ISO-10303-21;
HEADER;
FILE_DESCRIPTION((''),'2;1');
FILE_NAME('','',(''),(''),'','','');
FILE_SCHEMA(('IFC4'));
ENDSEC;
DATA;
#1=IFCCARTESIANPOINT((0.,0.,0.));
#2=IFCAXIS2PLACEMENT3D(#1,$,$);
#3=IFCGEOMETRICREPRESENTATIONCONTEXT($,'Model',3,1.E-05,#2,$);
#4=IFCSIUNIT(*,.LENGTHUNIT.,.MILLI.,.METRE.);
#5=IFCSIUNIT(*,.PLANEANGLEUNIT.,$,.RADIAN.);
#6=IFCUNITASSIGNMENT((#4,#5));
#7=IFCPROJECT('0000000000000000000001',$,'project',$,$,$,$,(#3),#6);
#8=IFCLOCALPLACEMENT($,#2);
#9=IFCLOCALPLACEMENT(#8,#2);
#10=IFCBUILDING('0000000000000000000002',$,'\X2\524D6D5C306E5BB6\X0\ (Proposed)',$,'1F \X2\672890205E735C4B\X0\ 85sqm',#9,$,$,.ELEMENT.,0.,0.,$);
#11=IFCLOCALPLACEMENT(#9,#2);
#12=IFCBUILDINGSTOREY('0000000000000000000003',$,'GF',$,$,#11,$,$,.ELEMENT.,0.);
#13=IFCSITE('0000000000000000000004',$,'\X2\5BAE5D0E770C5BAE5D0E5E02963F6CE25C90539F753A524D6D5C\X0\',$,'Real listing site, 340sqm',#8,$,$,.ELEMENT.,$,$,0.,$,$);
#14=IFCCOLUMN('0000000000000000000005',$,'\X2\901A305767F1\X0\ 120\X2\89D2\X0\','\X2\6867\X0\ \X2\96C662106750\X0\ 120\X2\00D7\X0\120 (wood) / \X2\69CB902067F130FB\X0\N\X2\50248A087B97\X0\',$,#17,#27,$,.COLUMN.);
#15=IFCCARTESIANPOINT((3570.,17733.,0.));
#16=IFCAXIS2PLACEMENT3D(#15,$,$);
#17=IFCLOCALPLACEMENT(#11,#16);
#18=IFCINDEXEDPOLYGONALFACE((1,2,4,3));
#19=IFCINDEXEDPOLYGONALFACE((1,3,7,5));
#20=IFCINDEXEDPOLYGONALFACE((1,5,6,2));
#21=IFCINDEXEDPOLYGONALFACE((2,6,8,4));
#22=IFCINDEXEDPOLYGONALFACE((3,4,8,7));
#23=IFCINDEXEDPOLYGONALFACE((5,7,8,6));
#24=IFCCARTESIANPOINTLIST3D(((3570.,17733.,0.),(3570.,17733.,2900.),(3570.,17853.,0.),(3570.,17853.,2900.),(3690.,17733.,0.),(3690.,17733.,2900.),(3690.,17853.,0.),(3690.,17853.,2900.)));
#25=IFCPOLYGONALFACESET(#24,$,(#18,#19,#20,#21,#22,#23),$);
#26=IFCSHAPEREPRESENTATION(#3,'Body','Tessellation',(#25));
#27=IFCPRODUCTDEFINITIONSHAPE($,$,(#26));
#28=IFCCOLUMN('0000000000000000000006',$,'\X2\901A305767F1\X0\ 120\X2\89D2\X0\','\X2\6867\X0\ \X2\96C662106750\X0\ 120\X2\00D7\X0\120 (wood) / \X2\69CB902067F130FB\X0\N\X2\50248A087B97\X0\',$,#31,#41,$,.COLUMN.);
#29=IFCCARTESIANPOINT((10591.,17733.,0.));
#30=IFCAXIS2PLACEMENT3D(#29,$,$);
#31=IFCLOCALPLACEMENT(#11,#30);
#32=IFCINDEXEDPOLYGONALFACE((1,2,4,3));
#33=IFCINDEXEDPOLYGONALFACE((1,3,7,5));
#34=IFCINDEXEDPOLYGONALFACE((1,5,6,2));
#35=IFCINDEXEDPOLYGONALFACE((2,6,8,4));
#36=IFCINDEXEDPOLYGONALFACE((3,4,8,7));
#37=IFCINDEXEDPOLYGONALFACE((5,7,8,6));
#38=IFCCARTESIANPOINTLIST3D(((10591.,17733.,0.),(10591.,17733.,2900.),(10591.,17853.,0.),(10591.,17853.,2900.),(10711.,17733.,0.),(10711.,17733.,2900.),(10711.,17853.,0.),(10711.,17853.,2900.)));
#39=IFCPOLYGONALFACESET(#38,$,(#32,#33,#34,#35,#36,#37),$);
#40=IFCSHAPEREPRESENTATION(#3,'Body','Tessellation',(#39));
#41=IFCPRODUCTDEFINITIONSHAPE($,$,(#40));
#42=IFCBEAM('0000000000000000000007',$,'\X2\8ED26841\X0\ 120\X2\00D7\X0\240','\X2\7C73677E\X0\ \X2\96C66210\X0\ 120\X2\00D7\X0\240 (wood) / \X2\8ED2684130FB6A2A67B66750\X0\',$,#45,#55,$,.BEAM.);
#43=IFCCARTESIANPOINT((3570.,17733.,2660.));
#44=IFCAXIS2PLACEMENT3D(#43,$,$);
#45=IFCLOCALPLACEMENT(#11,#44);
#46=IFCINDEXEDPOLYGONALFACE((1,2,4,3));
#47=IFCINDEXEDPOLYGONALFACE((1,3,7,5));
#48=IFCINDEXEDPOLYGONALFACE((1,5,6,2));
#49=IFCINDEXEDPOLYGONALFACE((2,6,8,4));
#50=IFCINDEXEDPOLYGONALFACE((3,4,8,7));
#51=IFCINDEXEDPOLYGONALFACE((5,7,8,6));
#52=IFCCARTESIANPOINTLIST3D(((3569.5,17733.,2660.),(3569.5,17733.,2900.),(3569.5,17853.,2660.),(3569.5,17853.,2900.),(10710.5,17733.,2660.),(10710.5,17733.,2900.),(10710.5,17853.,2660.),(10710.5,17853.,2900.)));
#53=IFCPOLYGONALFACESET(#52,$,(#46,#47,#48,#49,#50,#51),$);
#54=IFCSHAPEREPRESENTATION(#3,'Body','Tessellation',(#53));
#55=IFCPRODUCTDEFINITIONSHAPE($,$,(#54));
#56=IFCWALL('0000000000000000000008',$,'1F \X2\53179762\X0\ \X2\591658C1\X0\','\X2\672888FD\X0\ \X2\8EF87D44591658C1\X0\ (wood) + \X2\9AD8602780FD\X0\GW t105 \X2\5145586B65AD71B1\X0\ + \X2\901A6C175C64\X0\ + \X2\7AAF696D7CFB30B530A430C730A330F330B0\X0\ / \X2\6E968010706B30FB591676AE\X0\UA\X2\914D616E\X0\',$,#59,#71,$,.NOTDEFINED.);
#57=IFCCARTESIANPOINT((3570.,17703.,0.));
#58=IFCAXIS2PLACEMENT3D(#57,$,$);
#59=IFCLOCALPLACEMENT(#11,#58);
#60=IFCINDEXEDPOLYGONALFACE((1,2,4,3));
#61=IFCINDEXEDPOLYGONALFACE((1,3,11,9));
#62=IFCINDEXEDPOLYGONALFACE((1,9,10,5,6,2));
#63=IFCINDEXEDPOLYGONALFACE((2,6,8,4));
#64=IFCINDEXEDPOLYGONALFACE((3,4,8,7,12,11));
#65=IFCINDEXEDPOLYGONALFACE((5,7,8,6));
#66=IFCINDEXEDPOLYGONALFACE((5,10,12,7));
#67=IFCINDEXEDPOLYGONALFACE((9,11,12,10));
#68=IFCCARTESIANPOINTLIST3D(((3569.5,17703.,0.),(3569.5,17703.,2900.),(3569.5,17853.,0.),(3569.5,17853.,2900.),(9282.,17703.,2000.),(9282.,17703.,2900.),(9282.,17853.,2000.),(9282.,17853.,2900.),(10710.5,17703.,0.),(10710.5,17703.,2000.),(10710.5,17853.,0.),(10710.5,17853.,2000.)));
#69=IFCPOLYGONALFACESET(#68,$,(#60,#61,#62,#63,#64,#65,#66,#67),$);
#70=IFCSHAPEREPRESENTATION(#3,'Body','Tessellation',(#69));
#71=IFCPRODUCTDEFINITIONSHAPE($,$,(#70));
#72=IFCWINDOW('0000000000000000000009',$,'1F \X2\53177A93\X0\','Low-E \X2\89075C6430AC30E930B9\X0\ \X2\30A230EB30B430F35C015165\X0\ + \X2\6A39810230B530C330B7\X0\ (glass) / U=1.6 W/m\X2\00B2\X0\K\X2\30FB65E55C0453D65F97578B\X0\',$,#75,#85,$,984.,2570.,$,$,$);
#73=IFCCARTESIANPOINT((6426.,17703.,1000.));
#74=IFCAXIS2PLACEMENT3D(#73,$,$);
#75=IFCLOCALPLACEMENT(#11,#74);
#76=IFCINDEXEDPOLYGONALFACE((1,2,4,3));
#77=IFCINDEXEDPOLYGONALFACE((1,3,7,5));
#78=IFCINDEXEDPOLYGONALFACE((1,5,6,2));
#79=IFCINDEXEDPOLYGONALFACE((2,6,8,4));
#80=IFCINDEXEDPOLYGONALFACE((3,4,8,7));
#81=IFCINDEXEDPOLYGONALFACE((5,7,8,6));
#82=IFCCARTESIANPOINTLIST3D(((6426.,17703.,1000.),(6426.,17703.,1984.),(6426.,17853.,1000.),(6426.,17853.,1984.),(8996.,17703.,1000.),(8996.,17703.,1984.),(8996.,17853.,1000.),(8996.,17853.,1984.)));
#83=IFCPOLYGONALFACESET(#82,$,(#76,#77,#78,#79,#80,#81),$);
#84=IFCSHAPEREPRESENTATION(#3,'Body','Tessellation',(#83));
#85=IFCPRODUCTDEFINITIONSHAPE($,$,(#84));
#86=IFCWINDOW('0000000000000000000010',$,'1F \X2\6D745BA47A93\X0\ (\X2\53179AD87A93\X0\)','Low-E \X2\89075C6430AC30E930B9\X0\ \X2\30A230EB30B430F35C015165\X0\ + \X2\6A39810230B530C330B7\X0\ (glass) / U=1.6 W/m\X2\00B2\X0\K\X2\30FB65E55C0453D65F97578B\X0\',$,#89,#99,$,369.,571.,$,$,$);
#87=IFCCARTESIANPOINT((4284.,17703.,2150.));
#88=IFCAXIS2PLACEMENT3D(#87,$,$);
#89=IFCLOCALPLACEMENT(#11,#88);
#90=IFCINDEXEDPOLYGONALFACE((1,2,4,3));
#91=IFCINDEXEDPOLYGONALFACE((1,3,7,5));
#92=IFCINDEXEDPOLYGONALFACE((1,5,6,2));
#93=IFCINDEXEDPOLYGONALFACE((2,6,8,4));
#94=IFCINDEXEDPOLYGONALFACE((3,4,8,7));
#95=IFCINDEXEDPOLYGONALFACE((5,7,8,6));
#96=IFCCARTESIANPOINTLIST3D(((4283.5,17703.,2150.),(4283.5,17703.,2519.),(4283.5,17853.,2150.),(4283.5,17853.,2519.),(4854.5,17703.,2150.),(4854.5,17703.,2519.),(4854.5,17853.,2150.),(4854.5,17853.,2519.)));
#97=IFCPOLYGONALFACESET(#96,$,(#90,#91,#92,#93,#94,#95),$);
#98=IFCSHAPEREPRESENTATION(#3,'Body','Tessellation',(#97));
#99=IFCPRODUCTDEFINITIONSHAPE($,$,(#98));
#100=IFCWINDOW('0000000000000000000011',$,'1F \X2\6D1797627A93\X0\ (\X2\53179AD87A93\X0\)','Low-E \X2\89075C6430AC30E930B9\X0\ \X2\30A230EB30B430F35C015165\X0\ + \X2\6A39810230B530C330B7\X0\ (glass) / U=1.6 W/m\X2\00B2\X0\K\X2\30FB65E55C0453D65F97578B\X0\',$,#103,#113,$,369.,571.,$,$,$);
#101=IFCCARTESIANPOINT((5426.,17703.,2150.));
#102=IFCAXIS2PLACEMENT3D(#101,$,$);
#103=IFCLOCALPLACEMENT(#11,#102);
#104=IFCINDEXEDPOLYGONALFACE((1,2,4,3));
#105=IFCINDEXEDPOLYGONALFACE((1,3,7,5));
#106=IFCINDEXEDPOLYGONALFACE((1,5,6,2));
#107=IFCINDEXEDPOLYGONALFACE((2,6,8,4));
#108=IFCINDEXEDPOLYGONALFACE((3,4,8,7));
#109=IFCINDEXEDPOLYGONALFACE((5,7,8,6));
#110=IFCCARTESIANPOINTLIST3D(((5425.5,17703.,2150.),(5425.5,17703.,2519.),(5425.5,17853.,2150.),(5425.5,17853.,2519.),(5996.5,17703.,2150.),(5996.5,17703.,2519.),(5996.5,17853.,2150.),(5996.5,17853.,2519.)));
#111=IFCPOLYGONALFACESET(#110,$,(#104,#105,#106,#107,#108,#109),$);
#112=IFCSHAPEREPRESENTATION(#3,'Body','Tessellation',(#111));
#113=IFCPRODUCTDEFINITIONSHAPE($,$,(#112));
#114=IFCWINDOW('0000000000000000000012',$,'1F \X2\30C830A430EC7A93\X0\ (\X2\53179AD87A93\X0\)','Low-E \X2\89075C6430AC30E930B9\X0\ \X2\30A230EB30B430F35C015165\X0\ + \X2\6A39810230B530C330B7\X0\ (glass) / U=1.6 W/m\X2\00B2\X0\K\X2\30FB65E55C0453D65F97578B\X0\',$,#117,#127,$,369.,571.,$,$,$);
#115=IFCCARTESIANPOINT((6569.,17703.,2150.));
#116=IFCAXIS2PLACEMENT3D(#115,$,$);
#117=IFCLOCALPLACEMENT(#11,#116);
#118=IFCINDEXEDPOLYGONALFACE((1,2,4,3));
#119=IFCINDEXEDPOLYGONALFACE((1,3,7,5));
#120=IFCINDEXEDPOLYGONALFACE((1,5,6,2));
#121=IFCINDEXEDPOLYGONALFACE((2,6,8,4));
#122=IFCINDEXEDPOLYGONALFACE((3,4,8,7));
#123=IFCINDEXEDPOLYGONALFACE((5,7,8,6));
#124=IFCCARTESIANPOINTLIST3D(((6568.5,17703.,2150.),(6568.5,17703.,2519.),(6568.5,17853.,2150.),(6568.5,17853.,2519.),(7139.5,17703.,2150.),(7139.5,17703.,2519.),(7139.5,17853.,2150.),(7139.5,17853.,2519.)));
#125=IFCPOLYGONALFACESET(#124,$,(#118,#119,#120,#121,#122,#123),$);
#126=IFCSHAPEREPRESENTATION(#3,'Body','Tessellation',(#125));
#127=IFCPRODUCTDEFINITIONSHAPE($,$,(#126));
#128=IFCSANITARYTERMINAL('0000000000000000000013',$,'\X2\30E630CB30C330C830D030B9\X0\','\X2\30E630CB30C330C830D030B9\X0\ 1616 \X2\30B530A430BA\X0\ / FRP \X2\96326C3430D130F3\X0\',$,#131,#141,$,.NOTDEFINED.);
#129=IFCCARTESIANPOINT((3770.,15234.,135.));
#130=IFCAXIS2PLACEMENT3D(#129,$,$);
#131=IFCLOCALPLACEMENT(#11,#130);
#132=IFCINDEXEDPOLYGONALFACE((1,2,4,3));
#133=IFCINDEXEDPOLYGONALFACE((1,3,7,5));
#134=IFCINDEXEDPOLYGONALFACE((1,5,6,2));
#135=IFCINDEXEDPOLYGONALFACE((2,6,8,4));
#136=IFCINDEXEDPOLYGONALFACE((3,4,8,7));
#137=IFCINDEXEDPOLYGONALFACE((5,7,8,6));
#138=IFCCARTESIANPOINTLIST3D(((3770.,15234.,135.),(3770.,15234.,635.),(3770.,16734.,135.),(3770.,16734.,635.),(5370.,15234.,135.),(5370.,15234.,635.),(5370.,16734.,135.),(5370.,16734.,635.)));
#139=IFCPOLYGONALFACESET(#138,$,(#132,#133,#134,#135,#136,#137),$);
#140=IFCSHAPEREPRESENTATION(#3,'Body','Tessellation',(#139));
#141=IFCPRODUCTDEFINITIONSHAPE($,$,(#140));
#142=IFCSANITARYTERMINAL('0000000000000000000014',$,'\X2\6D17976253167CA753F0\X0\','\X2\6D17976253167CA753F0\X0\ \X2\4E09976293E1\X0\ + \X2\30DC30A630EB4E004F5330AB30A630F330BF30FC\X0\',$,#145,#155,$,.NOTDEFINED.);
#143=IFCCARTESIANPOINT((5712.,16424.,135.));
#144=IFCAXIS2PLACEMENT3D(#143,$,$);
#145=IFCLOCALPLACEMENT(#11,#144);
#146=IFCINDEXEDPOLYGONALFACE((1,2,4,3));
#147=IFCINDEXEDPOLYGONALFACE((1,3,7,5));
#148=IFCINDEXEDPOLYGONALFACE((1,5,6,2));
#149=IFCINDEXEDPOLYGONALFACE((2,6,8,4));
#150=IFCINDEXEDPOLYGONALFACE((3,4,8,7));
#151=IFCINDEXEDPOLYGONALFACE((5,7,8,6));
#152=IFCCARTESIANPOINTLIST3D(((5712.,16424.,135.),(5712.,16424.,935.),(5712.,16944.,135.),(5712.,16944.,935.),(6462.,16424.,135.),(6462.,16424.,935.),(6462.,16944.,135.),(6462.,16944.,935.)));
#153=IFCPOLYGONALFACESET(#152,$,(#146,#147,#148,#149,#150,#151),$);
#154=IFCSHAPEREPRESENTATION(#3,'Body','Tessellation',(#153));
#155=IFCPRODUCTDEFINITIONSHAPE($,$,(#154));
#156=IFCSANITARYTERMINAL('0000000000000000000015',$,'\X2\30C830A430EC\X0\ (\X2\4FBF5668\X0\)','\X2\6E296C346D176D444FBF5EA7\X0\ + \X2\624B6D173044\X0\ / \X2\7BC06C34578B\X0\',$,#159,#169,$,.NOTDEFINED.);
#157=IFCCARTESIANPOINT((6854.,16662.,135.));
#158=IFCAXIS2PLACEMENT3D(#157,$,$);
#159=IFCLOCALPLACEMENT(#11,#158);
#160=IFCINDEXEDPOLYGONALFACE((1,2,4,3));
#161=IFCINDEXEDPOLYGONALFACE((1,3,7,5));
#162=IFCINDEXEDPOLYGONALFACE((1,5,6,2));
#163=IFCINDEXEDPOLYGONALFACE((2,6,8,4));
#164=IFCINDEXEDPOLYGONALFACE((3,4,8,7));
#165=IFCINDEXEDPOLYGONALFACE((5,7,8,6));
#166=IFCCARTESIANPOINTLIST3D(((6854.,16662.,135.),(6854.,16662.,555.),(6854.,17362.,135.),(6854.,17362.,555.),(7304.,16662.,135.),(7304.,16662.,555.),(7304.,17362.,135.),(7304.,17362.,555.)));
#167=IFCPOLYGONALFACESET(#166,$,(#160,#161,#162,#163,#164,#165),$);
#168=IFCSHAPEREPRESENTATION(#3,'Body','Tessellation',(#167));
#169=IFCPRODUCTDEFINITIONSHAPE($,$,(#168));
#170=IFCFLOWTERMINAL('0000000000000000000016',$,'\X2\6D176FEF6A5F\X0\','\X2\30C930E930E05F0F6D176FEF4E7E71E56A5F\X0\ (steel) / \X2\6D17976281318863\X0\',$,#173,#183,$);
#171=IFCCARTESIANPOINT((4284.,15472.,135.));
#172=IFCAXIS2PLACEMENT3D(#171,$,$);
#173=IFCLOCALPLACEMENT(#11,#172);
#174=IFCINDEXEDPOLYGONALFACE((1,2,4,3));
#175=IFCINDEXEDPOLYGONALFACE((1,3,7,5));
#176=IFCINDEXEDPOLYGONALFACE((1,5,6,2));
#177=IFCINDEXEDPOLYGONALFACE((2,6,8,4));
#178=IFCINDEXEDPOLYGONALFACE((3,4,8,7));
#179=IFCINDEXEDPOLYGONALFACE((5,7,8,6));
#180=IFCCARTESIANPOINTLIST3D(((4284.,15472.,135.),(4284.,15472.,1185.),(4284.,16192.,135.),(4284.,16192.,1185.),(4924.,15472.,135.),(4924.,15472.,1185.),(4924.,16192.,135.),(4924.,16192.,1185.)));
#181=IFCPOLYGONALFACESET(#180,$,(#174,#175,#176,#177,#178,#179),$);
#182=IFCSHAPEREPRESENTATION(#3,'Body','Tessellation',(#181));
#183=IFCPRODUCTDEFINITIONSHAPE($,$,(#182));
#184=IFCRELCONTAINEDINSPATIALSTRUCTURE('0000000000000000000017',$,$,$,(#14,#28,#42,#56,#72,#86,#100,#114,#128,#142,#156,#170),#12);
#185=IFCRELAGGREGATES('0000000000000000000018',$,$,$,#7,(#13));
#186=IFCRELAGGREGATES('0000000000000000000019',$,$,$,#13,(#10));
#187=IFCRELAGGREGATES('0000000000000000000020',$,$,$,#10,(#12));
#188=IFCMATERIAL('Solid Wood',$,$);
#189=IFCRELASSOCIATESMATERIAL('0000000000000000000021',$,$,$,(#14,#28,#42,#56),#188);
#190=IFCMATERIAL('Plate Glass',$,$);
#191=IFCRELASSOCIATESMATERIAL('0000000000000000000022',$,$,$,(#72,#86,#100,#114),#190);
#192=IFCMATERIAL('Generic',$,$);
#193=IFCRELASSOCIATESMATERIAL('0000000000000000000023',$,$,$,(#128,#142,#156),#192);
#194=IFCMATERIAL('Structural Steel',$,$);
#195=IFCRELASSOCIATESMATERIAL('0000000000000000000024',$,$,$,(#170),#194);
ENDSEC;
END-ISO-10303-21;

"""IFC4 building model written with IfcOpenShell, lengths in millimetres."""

from ifc_helpers import new_model, si_unit, frame, frame_2d, origin, place, context, project, spatial, rectangle, extrude, material, element, fill, save


model = new_model("IFC4")

# Units and contexts
model_context = context("Model", 3, precision=1e-05, world=origin())
ifc_project = project(units=[si_unit("LENGTHUNIT", "METRE", prefix="MILLI"), si_unit("PLANEANGLEUNIT", "RADIAN")], contexts=[model_context])

# Site, building, storey
site_placement = place(None, origin())
site = spatial("IfcSite", under=ifc_project, at=site_placement, Name="宮崎県宮崎市阿波岐原町前浜", ObjectType="Real listing site, 340sqm", CompositionType="ELEMENT", RefElevation=0.0)
building_placement = place(site_placement, origin())
building = spatial("IfcBuilding", under=site, at=building_placement, Name="前浜の家 (Proposed)", ObjectType="1F 木造平屋 85sqm", CompositionType="ELEMENT", ElevationOfRefHeight=0.0, ElevationOfTerrain=0.0)
storey_placement = place(building_placement, origin())
storey = spatial("IfcBuildingStorey", under=building, at=storey_placement, Name="GF", CompositionType="ELEMENT", Elevation=0.0)

# Columns
ifc_material_1 = material(Name="Solid Wood")
column_1_placement = place(storey_placement, frame((3570.0, 17733.0, 0.0)))
element("IfcColumn", 1, at=column_1_placement, inside=storey, material=ifc_material_1, Name="通し柱 120角", Description="桧 集成材 120×120 (wood) / 構造柱・N値計算", PredefinedType="COLUMN", context=model_context, shape_type="SweptSolid", body=[
    extrude(rectangle(XDim=120.0, YDim=120.0, at=frame_2d((60.0, 60.0))), frame((3570.0, 17733.0, 0.0)), (0.0, 0.0, 1.0), 2900.0),
])
column_2_placement = place(storey_placement, frame((10591.0, 17733.0, 0.0)))
element("IfcColumn", 2, at=column_2_placement, inside=storey, material=ifc_material_1, Name="通し柱 120角", Description="桧 集成材 120×120 (wood) / 構造柱・N値計算", PredefinedType="COLUMN", context=model_context, shape_type="SweptSolid", body=[
    extrude(rectangle(XDim=120.0, YDim=120.0, at=frame_2d((60.0, 60.0))), frame((10591.0, 17733.0, 0.0)), (0.0, 0.0, 1.0), 2900.0),
])

# Beam
beam_1_placement = place(storey_placement, frame((3570.0, 17733.0, 2660.0)))
element("IfcBeam", 3, at=beam_1_placement, inside=storey, material=ifc_material_1, Name="軒桁 120×240", Description="米松 集成 120×240 (wood) / 軒桁・横架材", PredefinedType="BEAM", context=model_context, shape_type="SweptSolid", body=[
    extrude(rectangle(XDim=7141.0, YDim=120.0, at=frame_2d((3570.0, 60.0))), frame((3570.0, 17733.0, 2660.0)), (0.0, 0.0, 1.0), 240.0),
])

# Wall, openings, windows
wall_placement = place(storey_placement, frame((3570.0, 17703.0, 0.0)))
wall = element("IfcWall", 4, at=wall_placement, inside=storey, material=ifc_material_1, Name="1F 北面 外壁", Description="木製 軸組外壁 (wood) + 高性能GW t105 充填断熱 + 通気層 + 窯業系サイディング / 準耐火・外皮UA配慮", PredefinedType="NOTDEFINED", context=model_context, shape_type="SweptSolid", body=[
    extrude(rectangle(XDim=7141.0, YDim=150.0, at=frame_2d((3570.0, 75.0))), frame((3570.0, 17703.0, 0.0)), (0.0, 0.0, 1.0), 2900.0),
])
opening_1_placement = place(storey_placement, frame((6426.0, 17703.0, 1000.0)))
opening_1 = element("IfcOpeningElement", 5, at=opening_1_placement, cuts=wall, PredefinedType="NOTDEFINED", context=model_context, shape_type="SweptSolid", body=[
    extrude(rectangle(XDim=2570.0, YDim=150.0, at=frame_2d((1285.0, 75.0))), frame((6426.0, 17703.0, 1000.0)), (0.0, 0.0, 1.0), 984.0),
])
opening_2_placement = place(storey_placement, frame((4284.0, 17703.0, 2150.0)))
opening_2 = element("IfcOpeningElement", 6, at=opening_2_placement, cuts=wall, PredefinedType="NOTDEFINED", context=model_context, shape_type="SweptSolid", body=[
    extrude(rectangle(XDim=571.0, YDim=150.0, at=frame_2d((285.0, 75.0))), frame((4284.0, 17703.0, 2150.0)), (0.0, 0.0, 1.0), 369.0),
])
opening_3_placement = place(storey_placement, frame((5426.0, 17703.0, 2150.0)))
opening_3 = element("IfcOpeningElement", 7, at=opening_3_placement, cuts=wall, PredefinedType="NOTDEFINED", context=model_context, shape_type="SweptSolid", body=[
    extrude(rectangle(XDim=571.0, YDim=150.0, at=frame_2d((285.0, 75.0))), frame((5426.0, 17703.0, 2150.0)), (0.0, 0.0, 1.0), 369.0),
])
opening_4_placement = place(storey_placement, frame((6569.0, 17703.0, 2150.0)))
opening_4 = element("IfcOpeningElement", 8, at=opening_4_placement, cuts=wall, PredefinedType="NOTDEFINED", context=model_context, shape_type="SweptSolid", body=[
    extrude(rectangle(XDim=571.0, YDim=150.0, at=frame_2d((285.0, 75.0))), frame((6569.0, 17703.0, 2150.0)), (0.0, 0.0, 1.0), 369.0),
])
ifc_material_2 = material(Name="Plate Glass")
window_1_placement = place(storey_placement, frame((6426.0, 17703.0, 1000.0)))
window_1 = element("IfcWindow", 9, at=window_1_placement, inside=storey, material=ifc_material_2, Name="1F 北窓", Description="Low-E 複層ガラス アルゴン封入 + 樹脂サッシ (glass) / U=1.6 W/m²K・日射取得型", OverallHeight=984.0, OverallWidth=2570.0, context=model_context, shape_type="SweptSolid", body=[
    extrude(rectangle(XDim=2570.0, YDim=150.0, at=frame_2d((1285.0, 75.0))), frame((6426.0, 17703.0, 1000.0)), (0.0, 0.0, 1.0), 984.0),
])
fill(opening_1, window_1)
window_2_placement = place(storey_placement, frame((4284.0, 17703.0, 2150.0)))
window_2 = element("IfcWindow", 10, at=window_2_placement, inside=storey, material=ifc_material_2, Name="1F 浴室窓 (北高窓)", Description="Low-E 複層ガラス アルゴン封入 + 樹脂サッシ (glass) / U=1.6 W/m²K・日射取得型", OverallHeight=369.0, OverallWidth=571.0, context=model_context, shape_type="SweptSolid", body=[
    extrude(rectangle(XDim=571.0, YDim=150.0, at=frame_2d((285.0, 75.0))), frame((4284.0, 17703.0, 2150.0)), (0.0, 0.0, 1.0), 369.0),
])
fill(opening_2, window_2)
window_3_placement = place(storey_placement, frame((5426.0, 17703.0, 2150.0)))
window_3 = element("IfcWindow", 11, at=window_3_placement, inside=storey, material=ifc_material_2, Name="1F 洗面窓 (北高窓)", Description="Low-E 複層ガラス アルゴン封入 + 樹脂サッシ (glass) / U=1.6 W/m²K・日射取得型", OverallHeight=369.0, OverallWidth=571.0, context=model_context, shape_type="SweptSolid", body=[
    extrude(rectangle(XDim=571.0, YDim=150.0, at=frame_2d((285.0, 75.0))), frame((5426.0, 17703.0, 2150.0)), (0.0, 0.0, 1.0), 369.0),
])
fill(opening_3, window_3)
window_4_placement = place(storey_placement, frame((6569.0, 17703.0, 2150.0)))
window_4 = element("IfcWindow", 12, at=window_4_placement, inside=storey, material=ifc_material_2, Name="1F トイレ窓 (北高窓)", Description="Low-E 複層ガラス アルゴン封入 + 樹脂サッシ (glass) / U=1.6 W/m²K・日射取得型", OverallHeight=369.0, OverallWidth=571.0, context=model_context, shape_type="SweptSolid", body=[
    extrude(rectangle(XDim=571.0, YDim=150.0, at=frame_2d((285.0, 75.0))), frame((6569.0, 17703.0, 2150.0)), (0.0, 0.0, 1.0), 369.0),
])
fill(opening_4, window_4)

# Sanitary terminals
ifc_material_3 = material(Name="Generic")
sanitary_terminal_1_placement = place(storey_placement, frame((3770.0, 15234.0, 135.0)))
element("IfcSanitaryTerminal", 13, at=sanitary_terminal_1_placement, inside=storey, material=ifc_material_3, Name="ユニットバス", Description="ユニットバス 1616 サイズ / FRP 防水パン", PredefinedType="NOTDEFINED", context=model_context, shape_type="SweptSolid", body=[
    extrude(rectangle(XDim=1600.0, YDim=1500.0, at=frame_2d((800.0, 750.0))), frame((3770.0, 15234.0, 135.0)), (0.0, 0.0, 1.0), 500.0),
])
sanitary_terminal_2_placement = place(storey_placement, frame((5712.0, 16424.0, 135.0)))
element("IfcSanitaryTerminal", 14, at=sanitary_terminal_2_placement, inside=storey, material=ifc_material_3, Name="洗面化粧台", Description="洗面化粧台 三面鏡 + ボウル一体カウンター", PredefinedType="NOTDEFINED", context=model_context, shape_type="SweptSolid", body=[
    extrude(rectangle(XDim=750.0, YDim=520.0, at=frame_2d((375.0, 260.0))), frame((5712.0, 16424.0, 135.0)), (0.0, 0.0, 1.0), 800.0),
])
sanitary_terminal_3_placement = place(storey_placement, frame((6854.0, 16662.0, 135.0)))
element("IfcSanitaryTerminal", 15, at=sanitary_terminal_3_placement, inside=storey, material=ifc_material_3, Name="トイレ (便器)", Description="温水洗浄便座 + 手洗い / 節水型", PredefinedType="NOTDEFINED", context=model_context, shape_type="SweptSolid", body=[
    extrude(rectangle(XDim=450.0, YDim=700.0, at=frame_2d((225.0, 350.0))), frame((6854.0, 16662.0, 135.0)), (0.0, 0.0, 1.0), 420.0),
])

# Flow terminal
ifc_material_4 = material(Name="Structural Steel")
flow_terminal_placement = place(storey_placement, frame((4284.0, 15472.0, 135.0)))
element("IfcFlowTerminal", 16, at=flow_terminal_placement, inside=storey, material=ifc_material_4, Name="洗濯機", Description="ドラム式洗濯乾燥機 (steel) / 洗面脱衣", context=model_context, shape_type="SweptSolid", body=[
    extrude(rectangle(XDim=640.0, YDim=720.0, at=frame_2d((320.0, 360.0))), frame((4284.0, 15472.0, 135.0)), (0.0, 0.0, 1.0), 1050.0),
])

save(model, "model.ifc")
